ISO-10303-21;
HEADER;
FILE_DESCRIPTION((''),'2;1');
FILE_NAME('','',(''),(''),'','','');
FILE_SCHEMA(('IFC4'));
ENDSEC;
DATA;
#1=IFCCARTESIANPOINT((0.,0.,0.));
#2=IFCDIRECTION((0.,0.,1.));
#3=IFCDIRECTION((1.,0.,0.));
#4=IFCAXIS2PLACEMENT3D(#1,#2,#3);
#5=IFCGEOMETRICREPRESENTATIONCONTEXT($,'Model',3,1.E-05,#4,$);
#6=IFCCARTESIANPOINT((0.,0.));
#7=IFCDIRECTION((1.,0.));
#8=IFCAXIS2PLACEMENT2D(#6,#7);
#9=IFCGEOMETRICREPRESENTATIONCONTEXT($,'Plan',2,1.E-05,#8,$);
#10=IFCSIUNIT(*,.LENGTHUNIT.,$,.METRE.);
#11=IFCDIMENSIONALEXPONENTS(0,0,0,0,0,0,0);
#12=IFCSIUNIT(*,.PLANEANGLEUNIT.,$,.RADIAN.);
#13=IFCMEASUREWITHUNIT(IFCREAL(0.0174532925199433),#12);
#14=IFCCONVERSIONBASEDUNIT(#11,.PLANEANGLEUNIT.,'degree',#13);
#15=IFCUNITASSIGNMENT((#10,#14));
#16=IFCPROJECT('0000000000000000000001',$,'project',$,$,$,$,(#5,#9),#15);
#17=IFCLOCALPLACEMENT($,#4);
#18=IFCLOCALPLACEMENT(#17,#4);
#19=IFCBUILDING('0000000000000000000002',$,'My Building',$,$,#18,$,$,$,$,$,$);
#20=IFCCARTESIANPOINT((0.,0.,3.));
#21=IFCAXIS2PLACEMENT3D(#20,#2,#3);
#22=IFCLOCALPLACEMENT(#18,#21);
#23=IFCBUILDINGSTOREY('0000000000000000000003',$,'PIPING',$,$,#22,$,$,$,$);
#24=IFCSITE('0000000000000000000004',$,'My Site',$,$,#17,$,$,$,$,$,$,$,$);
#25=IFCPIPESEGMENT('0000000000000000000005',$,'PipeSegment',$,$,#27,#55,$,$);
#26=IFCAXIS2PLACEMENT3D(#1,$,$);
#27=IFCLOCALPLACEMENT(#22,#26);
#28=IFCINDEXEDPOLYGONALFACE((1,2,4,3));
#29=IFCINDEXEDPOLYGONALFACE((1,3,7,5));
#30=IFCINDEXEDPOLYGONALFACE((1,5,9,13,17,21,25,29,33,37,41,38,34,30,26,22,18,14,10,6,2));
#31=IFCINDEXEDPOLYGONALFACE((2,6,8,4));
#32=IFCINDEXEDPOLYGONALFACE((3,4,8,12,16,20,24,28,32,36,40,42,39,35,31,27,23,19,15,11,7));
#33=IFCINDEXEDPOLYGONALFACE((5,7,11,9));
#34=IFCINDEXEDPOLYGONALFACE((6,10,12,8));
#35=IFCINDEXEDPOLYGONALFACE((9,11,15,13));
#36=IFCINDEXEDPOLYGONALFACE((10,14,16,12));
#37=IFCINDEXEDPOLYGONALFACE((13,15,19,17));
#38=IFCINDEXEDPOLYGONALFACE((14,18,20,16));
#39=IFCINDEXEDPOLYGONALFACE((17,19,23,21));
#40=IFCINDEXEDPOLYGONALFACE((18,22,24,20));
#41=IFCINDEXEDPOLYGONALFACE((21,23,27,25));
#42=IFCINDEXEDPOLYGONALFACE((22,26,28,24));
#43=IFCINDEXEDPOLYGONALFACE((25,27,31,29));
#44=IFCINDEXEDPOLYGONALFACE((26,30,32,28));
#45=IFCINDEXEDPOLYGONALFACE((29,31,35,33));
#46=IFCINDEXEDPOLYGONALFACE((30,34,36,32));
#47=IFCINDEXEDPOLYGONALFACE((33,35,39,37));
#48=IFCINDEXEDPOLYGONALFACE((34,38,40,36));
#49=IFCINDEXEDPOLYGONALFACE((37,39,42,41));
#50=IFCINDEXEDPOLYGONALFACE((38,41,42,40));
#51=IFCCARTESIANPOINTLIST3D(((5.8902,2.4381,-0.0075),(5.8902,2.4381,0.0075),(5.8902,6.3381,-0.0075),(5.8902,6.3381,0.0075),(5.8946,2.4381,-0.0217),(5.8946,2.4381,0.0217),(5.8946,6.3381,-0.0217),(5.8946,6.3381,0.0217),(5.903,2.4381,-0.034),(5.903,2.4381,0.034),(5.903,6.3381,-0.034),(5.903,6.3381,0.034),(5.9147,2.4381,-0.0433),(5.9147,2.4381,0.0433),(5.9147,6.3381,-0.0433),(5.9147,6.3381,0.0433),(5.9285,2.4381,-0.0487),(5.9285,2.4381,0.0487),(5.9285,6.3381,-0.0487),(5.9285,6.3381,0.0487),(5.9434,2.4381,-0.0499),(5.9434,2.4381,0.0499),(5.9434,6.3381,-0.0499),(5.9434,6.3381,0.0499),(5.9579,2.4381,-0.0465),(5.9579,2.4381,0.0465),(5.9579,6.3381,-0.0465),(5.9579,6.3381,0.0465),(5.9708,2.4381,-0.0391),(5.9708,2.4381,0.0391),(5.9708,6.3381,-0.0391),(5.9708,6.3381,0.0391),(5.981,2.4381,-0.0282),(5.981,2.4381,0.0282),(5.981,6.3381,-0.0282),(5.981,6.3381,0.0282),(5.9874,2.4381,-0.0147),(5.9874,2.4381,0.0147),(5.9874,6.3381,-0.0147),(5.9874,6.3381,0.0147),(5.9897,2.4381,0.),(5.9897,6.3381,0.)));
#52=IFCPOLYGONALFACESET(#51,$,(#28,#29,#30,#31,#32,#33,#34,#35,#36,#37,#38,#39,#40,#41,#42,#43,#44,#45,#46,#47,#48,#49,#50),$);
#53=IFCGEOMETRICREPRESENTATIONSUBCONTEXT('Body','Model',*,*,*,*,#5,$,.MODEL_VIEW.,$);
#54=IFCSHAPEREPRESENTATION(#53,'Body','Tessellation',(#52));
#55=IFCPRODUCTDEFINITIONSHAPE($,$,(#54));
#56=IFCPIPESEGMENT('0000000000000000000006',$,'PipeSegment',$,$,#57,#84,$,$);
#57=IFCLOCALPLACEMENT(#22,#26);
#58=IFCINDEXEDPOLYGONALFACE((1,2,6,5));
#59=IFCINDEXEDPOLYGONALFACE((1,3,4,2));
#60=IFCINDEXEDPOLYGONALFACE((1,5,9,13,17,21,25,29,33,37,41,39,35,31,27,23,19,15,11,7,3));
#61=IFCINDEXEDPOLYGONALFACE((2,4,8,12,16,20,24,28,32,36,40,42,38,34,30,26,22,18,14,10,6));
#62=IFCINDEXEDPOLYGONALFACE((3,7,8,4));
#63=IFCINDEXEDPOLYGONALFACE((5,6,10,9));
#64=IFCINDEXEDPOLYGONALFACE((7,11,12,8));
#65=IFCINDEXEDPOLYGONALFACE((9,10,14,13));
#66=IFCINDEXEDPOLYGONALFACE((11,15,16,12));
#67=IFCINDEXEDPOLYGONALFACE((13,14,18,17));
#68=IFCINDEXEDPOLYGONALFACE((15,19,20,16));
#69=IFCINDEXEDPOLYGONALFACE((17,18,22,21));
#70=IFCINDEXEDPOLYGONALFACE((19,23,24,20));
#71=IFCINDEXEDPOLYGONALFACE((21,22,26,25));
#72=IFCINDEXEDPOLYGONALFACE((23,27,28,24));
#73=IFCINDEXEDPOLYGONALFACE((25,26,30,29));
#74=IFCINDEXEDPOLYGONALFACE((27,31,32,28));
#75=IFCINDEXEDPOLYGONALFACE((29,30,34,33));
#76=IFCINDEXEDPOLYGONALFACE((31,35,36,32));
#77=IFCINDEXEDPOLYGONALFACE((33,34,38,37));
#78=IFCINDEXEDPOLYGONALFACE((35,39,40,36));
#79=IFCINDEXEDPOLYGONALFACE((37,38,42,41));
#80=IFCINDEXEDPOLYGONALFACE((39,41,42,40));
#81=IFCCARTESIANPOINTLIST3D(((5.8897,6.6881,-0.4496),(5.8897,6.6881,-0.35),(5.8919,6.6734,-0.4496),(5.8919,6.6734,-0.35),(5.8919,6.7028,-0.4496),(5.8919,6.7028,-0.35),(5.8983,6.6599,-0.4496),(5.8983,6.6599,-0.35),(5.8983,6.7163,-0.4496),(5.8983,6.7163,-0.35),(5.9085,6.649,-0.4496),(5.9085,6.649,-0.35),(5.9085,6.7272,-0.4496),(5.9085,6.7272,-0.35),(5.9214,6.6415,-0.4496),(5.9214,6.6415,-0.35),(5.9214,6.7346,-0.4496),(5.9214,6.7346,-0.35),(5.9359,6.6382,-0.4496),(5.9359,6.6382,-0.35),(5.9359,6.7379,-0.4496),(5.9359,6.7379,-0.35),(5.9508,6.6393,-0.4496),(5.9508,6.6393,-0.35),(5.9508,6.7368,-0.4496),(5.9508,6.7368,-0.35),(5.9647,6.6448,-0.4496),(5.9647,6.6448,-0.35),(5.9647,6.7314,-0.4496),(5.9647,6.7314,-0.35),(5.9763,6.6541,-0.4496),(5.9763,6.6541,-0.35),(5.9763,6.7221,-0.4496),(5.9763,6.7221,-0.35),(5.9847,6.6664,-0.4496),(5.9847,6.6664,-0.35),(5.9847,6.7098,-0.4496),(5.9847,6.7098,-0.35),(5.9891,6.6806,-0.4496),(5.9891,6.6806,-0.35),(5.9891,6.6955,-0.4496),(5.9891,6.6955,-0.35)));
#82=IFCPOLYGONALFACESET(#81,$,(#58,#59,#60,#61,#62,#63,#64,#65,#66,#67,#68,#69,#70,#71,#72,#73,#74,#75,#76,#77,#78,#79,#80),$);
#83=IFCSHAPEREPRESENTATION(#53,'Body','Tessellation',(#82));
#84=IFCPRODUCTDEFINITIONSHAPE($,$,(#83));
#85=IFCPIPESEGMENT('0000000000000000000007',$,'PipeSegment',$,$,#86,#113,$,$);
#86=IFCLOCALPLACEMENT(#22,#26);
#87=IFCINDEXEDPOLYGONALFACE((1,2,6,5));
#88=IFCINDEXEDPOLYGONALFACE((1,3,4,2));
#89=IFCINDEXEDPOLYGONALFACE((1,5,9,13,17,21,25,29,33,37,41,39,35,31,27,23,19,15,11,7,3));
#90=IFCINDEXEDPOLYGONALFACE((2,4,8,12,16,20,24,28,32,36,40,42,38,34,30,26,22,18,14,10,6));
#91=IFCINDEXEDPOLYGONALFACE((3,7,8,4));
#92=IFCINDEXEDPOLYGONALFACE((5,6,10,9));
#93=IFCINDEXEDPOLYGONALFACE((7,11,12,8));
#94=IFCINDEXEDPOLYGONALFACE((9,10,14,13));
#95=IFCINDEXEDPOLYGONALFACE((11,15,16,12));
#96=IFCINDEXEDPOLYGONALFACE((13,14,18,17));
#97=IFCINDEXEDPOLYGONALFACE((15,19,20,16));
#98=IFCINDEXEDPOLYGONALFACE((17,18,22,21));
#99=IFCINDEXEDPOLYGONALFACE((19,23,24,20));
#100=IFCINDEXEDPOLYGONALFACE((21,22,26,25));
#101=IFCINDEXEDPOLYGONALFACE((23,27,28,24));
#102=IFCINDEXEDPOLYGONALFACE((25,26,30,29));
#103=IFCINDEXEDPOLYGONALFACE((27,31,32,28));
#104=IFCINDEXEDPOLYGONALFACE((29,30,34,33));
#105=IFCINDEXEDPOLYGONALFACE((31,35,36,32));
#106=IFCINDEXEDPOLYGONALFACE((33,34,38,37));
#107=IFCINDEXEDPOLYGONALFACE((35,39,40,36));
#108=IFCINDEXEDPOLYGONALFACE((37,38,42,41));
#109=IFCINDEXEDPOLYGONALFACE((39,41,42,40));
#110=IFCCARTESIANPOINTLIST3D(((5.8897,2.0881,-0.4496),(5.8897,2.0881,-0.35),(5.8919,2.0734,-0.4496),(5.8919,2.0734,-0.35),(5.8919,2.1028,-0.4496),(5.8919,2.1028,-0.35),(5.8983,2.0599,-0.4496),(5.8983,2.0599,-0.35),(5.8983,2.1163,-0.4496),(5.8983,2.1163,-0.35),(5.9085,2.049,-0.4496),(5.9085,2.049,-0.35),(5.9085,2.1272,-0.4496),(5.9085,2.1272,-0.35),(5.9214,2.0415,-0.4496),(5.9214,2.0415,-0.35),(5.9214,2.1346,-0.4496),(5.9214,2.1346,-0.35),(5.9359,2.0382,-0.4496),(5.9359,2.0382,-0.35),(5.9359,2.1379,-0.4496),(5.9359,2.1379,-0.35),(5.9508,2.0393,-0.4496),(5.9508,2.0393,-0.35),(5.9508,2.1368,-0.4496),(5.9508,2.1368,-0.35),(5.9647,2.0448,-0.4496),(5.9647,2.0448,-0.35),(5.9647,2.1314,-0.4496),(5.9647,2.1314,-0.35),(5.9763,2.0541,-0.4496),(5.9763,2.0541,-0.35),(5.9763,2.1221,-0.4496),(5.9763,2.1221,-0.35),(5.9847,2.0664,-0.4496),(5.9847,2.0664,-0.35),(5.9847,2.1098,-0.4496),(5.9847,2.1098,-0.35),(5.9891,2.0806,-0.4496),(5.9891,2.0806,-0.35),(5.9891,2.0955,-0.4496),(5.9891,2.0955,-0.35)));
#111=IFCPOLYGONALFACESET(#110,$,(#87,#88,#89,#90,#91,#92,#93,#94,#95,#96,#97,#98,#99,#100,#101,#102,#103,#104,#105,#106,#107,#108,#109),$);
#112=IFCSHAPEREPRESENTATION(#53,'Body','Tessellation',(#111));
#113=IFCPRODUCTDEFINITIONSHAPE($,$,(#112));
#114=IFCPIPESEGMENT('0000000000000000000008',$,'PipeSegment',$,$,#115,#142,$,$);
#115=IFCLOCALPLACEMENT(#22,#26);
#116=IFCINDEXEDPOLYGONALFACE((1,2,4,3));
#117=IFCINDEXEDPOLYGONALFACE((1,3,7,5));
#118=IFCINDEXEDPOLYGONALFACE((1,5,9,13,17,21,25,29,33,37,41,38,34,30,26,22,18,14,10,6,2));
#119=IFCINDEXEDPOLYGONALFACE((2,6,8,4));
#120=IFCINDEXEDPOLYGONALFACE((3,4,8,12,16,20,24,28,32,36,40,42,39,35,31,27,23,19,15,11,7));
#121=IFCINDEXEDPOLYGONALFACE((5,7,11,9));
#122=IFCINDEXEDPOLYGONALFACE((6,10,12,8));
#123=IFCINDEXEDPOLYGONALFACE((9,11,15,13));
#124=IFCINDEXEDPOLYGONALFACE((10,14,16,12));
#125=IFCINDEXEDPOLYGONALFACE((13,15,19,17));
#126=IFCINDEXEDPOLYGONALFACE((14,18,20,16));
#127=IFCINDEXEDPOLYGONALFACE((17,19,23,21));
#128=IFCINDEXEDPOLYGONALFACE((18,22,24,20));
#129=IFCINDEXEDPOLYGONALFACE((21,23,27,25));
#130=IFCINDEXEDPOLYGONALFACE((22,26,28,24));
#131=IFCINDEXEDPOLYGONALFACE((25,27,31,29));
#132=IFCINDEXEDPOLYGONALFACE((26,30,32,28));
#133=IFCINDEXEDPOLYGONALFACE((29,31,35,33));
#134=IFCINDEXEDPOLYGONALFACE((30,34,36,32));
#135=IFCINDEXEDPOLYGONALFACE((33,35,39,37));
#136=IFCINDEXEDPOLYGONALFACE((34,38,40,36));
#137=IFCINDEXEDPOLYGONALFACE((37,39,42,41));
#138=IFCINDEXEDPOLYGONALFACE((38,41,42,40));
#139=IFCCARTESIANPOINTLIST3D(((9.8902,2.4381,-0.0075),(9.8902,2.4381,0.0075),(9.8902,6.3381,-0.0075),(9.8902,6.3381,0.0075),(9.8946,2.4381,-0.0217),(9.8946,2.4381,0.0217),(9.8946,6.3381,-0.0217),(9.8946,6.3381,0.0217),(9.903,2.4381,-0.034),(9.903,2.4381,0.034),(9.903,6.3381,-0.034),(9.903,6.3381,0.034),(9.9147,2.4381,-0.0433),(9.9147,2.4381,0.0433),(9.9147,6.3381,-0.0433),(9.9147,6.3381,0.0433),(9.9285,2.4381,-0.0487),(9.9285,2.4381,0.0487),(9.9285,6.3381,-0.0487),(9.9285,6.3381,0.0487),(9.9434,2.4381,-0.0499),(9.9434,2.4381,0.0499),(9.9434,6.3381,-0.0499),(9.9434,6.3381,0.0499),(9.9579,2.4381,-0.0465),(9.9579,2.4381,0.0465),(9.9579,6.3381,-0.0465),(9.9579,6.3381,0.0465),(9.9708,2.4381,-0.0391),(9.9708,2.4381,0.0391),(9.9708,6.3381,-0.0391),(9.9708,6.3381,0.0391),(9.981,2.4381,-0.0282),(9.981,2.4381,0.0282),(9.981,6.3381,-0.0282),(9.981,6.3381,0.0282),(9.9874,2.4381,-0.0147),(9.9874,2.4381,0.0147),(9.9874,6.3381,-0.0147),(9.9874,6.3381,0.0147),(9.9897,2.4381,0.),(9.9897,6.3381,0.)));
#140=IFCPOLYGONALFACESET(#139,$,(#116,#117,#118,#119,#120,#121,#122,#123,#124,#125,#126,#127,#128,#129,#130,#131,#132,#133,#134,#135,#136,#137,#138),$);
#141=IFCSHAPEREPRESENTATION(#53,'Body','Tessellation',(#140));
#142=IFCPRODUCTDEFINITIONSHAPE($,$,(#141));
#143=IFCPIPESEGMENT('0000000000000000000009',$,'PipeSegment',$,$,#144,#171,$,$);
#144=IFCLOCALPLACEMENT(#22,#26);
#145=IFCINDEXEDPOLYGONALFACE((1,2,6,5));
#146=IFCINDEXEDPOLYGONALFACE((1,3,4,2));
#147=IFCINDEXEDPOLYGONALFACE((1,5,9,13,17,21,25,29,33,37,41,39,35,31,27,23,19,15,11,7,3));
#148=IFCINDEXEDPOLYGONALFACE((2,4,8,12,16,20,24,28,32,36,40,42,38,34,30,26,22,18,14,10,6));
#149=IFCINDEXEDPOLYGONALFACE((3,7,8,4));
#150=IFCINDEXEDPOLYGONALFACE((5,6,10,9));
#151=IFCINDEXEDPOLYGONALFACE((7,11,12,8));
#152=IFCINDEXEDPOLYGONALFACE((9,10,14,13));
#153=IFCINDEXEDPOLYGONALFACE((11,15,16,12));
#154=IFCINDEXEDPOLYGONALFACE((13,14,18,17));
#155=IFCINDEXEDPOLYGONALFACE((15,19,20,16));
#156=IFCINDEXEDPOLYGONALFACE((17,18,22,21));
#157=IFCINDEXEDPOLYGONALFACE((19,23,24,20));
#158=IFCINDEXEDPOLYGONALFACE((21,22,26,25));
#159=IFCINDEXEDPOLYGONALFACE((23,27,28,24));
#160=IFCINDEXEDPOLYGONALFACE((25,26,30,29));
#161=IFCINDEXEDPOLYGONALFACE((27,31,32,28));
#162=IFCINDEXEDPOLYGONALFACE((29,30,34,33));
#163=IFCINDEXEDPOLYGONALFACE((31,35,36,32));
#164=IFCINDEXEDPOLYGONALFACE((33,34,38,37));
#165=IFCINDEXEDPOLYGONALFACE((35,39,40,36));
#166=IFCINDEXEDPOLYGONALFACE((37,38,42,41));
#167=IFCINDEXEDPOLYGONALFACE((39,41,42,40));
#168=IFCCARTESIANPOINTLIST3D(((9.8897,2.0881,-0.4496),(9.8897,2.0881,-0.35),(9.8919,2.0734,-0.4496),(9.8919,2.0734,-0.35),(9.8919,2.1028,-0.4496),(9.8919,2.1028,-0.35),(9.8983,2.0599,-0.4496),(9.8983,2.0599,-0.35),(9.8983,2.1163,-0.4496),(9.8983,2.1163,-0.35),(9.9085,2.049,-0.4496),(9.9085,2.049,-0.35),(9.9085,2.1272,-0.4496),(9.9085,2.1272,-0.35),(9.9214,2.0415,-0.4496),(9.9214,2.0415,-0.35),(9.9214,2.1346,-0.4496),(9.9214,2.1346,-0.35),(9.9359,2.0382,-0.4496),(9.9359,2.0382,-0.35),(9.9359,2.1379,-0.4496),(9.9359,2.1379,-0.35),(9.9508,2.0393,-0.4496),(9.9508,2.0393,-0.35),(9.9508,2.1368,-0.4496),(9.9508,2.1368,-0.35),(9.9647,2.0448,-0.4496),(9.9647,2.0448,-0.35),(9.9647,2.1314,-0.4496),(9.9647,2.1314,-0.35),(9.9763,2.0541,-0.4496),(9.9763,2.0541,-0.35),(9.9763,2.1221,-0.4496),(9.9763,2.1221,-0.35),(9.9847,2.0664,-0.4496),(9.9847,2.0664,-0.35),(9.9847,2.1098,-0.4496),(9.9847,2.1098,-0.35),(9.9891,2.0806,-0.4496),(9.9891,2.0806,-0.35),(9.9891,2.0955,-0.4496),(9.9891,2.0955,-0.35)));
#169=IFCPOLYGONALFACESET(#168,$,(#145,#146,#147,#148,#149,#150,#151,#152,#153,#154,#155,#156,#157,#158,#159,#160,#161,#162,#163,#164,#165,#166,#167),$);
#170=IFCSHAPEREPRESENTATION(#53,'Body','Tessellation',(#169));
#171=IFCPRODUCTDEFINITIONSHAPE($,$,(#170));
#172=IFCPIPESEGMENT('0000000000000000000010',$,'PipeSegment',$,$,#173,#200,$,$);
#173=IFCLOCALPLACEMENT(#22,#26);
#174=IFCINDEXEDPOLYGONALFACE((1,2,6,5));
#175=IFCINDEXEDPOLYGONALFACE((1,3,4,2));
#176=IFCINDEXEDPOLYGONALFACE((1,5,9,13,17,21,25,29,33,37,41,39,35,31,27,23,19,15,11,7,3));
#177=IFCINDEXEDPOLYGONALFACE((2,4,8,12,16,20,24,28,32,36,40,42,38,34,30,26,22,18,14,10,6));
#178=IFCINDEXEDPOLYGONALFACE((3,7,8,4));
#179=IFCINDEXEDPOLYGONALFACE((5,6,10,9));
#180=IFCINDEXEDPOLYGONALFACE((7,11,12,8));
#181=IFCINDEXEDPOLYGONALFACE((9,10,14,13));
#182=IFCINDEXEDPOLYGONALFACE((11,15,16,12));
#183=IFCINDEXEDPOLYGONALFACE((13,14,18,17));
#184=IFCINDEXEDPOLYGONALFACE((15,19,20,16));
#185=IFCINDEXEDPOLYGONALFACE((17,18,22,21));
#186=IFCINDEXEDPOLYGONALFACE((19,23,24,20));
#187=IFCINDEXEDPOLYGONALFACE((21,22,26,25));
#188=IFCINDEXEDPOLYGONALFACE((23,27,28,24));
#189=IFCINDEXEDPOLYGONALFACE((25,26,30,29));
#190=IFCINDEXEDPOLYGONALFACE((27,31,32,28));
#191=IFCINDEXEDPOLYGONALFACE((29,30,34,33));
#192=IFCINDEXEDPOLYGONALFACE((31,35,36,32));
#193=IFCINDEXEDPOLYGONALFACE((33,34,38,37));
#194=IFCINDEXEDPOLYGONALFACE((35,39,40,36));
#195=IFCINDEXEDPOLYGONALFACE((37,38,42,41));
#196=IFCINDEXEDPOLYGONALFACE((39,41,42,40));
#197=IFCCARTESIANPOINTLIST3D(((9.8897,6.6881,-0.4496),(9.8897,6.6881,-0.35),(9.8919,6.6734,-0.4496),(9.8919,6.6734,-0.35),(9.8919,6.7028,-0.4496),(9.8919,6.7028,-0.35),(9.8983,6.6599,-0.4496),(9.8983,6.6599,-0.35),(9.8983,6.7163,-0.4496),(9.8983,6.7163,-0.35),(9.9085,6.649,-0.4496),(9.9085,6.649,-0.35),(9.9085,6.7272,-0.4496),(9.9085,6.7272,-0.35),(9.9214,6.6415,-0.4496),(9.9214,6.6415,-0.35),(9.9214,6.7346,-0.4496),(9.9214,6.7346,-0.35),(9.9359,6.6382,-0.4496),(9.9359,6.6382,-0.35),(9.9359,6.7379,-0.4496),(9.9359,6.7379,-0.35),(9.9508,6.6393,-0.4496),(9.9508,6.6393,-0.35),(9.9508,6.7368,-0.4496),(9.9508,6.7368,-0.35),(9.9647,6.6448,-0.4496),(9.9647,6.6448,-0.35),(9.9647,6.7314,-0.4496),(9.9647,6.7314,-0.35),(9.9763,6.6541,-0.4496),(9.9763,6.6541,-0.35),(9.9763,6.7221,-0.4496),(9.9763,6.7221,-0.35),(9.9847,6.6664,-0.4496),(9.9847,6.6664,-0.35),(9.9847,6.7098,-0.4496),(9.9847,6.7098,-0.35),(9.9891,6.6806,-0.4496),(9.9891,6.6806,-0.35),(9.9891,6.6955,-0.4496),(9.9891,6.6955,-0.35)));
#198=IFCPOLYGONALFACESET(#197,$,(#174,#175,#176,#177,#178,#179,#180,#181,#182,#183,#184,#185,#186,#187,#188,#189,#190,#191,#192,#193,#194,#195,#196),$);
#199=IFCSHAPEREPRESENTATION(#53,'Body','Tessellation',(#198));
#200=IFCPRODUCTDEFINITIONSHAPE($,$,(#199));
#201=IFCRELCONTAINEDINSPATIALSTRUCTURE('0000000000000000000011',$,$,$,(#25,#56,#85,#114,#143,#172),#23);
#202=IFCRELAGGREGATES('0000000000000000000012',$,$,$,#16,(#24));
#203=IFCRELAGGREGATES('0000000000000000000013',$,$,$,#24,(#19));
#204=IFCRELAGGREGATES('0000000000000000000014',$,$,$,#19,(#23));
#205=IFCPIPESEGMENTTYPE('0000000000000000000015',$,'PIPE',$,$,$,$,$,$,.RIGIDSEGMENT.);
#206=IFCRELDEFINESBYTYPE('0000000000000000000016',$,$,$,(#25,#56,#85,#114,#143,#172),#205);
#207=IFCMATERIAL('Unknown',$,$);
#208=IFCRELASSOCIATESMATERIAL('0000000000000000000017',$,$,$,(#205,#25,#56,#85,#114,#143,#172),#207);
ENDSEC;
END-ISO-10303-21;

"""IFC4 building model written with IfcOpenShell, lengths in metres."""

from ifc_helpers import new_model, entity, si_unit, converted_unit, frame, origin_with_axes, origin_2d_with_axis, place, context, subcontext, project, spatial, circle, extrude, material, material_profile, profile_set, profile_usage, type_object, element, save


model = new_model("IFC4")

# Units and contexts
model_context = context("Model", 3, precision=1e-05, world=origin_with_axes())
plan_context = context("Plan", 2, precision=1e-05, world=origin_2d_with_axis())
body_context = subcontext(model_context, "Body", "Model", "MODEL_VIEW")
ifc_project = project(units=[si_unit("LENGTHUNIT", "METRE"), converted_unit("PLANEANGLEUNIT", "degree", entity("IfcReal", 0.0174532925199433), si_unit("PLANEANGLEUNIT", "RADIAN"), dimensions=[0, 0, 0, 0, 0, 0, 0])], contexts=[model_context, plan_context])

# Site, building, storey
site_placement = place(None, origin_with_axes())
site = spatial("IfcSite", under=ifc_project, at=site_placement, Name="My Site")
building_placement = place(site_placement, origin_with_axes())
building = spatial("IfcBuilding", under=site, at=building_placement, Name="My Building")
storey_placement = place(building_placement, frame((0.0, 0.0, 3.0), z_axis=(0.0, 0.0, 1.0), x_axis=(1.0, 0.0, 0.0)))
storey = spatial("IfcBuildingStorey", under=building, at=storey_placement, Name="PIPING")

# Pipe segments
ifc_material = material(Name="Unknown")
ifc_material_profile = material_profile(ifc_material, circle(Radius=0.05))
ifc_profile_set = profile_set([ifc_material_profile])
pipe_segment_type = type_object("IfcPipeSegmentType", Name="PIPE", PredefinedType="RIGIDSEGMENT", material=ifc_profile_set)
ifc_profile_usage_1 = profile_usage(ifc_profile_set, cardinal=5)
pipe_segment_1_placement = place(storey_placement, frame((5.9397, 6.3381, 0.0), z_axis=(0.0, -1.0, 0.0), x_axis=(1.0, 0.0, 0.0)))
element("IfcPipeSegment", 1, at=pipe_segment_1_placement, inside=storey, type_object=pipe_segment_type, material=ifc_profile_usage_1, Name="PipeSegment", context=body_context, shape_type="SweptSolid", body=[
    extrude(circle(Radius=0.05), origin_with_axes(), (0.0, 0.0, 1.0), 3.9),
])
ifc_profile_usage_2 = profile_usage(ifc_profile_set, cardinal=5)
pipe_segment_2_placement = place(storey_placement, frame((5.9397, 6.6881, -0.35), z_axis=(0.0, 0.0, -1.0), x_axis=(-1.0, 0.0, 0.0)))
element("IfcPipeSegment", 2, at=pipe_segment_2_placement, inside=storey, type_object=pipe_segment_type, material=ifc_profile_usage_2, Name="PipeSegment", context=body_context, shape_type="SweptSolid", body=[
    extrude(circle(Radius=0.05), origin_with_axes(), (0.0, 0.0, 1.0), 0.0996),
])
ifc_profile_usage_3 = profile_usage(ifc_profile_set, cardinal=5)
pipe_segment_3_placement = place(storey_placement, frame((5.9397, 2.0881, -0.35), z_axis=(0.0, 0.0, -1.0), x_axis=(-1.0, 0.0, 0.0)))
element("IfcPipeSegment", 3, at=pipe_segment_3_placement, inside=storey, type_object=pipe_segment_type, material=ifc_profile_usage_3, Name="PipeSegment", context=body_context, shape_type="SweptSolid", body=[
    extrude(circle(Radius=0.05), origin_with_axes(), (0.0, 0.0, 1.0), 0.0996),
])
ifc_profile_usage_4 = profile_usage(ifc_profile_set, cardinal=5)
pipe_segment_4_placement = place(storey_placement, frame((9.9397, 6.3381, 0.0), z_axis=(0.0, -1.0, 0.0), x_axis=(1.0, 0.0, 0.0)))
element("IfcPipeSegment", 4, at=pipe_segment_4_placement, inside=storey, type_object=pipe_segment_type, material=ifc_profile_usage_4, Name="PipeSegment", context=body_context, shape_type="SweptSolid", body=[
    extrude(circle(Radius=0.05), origin_with_axes(), (0.0, 0.0, 1.0), 3.9),
])
ifc_profile_usage_5 = profile_usage(ifc_profile_set, cardinal=5)
pipe_segment_5_placement = place(storey_placement, frame((9.9397, 2.0881, -0.35), z_axis=(0.0, 0.0, -1.0), x_axis=(-1.0, 0.0, 0.0)))
element("IfcPipeSegment", 5, at=pipe_segment_5_placement, inside=storey, type_object=pipe_segment_type, material=ifc_profile_usage_5, Name="PipeSegment", context=body_context, shape_type="SweptSolid", body=[
    extrude(circle(Radius=0.05), origin_with_axes(), (0.0, 0.0, 1.0), 0.0996),
])
ifc_profile_usage_6 = profile_usage(ifc_profile_set, cardinal=5)
pipe_segment_6_placement = place(storey_placement, frame((9.9397, 6.6881, -0.35), z_axis=(0.0, 0.0, -1.0), x_axis=(-1.0, 0.0, 0.0)))
element("IfcPipeSegment", 6, at=pipe_segment_6_placement, inside=storey, type_object=pipe_segment_type, material=ifc_profile_usage_6, Name="PipeSegment", context=body_context, shape_type="SweptSolid", body=[
    extrude(circle(Radius=0.05), origin_with_axes(), (0.0, 0.0, 1.0), 0.0996),
])

save(model, "model.ifc")
